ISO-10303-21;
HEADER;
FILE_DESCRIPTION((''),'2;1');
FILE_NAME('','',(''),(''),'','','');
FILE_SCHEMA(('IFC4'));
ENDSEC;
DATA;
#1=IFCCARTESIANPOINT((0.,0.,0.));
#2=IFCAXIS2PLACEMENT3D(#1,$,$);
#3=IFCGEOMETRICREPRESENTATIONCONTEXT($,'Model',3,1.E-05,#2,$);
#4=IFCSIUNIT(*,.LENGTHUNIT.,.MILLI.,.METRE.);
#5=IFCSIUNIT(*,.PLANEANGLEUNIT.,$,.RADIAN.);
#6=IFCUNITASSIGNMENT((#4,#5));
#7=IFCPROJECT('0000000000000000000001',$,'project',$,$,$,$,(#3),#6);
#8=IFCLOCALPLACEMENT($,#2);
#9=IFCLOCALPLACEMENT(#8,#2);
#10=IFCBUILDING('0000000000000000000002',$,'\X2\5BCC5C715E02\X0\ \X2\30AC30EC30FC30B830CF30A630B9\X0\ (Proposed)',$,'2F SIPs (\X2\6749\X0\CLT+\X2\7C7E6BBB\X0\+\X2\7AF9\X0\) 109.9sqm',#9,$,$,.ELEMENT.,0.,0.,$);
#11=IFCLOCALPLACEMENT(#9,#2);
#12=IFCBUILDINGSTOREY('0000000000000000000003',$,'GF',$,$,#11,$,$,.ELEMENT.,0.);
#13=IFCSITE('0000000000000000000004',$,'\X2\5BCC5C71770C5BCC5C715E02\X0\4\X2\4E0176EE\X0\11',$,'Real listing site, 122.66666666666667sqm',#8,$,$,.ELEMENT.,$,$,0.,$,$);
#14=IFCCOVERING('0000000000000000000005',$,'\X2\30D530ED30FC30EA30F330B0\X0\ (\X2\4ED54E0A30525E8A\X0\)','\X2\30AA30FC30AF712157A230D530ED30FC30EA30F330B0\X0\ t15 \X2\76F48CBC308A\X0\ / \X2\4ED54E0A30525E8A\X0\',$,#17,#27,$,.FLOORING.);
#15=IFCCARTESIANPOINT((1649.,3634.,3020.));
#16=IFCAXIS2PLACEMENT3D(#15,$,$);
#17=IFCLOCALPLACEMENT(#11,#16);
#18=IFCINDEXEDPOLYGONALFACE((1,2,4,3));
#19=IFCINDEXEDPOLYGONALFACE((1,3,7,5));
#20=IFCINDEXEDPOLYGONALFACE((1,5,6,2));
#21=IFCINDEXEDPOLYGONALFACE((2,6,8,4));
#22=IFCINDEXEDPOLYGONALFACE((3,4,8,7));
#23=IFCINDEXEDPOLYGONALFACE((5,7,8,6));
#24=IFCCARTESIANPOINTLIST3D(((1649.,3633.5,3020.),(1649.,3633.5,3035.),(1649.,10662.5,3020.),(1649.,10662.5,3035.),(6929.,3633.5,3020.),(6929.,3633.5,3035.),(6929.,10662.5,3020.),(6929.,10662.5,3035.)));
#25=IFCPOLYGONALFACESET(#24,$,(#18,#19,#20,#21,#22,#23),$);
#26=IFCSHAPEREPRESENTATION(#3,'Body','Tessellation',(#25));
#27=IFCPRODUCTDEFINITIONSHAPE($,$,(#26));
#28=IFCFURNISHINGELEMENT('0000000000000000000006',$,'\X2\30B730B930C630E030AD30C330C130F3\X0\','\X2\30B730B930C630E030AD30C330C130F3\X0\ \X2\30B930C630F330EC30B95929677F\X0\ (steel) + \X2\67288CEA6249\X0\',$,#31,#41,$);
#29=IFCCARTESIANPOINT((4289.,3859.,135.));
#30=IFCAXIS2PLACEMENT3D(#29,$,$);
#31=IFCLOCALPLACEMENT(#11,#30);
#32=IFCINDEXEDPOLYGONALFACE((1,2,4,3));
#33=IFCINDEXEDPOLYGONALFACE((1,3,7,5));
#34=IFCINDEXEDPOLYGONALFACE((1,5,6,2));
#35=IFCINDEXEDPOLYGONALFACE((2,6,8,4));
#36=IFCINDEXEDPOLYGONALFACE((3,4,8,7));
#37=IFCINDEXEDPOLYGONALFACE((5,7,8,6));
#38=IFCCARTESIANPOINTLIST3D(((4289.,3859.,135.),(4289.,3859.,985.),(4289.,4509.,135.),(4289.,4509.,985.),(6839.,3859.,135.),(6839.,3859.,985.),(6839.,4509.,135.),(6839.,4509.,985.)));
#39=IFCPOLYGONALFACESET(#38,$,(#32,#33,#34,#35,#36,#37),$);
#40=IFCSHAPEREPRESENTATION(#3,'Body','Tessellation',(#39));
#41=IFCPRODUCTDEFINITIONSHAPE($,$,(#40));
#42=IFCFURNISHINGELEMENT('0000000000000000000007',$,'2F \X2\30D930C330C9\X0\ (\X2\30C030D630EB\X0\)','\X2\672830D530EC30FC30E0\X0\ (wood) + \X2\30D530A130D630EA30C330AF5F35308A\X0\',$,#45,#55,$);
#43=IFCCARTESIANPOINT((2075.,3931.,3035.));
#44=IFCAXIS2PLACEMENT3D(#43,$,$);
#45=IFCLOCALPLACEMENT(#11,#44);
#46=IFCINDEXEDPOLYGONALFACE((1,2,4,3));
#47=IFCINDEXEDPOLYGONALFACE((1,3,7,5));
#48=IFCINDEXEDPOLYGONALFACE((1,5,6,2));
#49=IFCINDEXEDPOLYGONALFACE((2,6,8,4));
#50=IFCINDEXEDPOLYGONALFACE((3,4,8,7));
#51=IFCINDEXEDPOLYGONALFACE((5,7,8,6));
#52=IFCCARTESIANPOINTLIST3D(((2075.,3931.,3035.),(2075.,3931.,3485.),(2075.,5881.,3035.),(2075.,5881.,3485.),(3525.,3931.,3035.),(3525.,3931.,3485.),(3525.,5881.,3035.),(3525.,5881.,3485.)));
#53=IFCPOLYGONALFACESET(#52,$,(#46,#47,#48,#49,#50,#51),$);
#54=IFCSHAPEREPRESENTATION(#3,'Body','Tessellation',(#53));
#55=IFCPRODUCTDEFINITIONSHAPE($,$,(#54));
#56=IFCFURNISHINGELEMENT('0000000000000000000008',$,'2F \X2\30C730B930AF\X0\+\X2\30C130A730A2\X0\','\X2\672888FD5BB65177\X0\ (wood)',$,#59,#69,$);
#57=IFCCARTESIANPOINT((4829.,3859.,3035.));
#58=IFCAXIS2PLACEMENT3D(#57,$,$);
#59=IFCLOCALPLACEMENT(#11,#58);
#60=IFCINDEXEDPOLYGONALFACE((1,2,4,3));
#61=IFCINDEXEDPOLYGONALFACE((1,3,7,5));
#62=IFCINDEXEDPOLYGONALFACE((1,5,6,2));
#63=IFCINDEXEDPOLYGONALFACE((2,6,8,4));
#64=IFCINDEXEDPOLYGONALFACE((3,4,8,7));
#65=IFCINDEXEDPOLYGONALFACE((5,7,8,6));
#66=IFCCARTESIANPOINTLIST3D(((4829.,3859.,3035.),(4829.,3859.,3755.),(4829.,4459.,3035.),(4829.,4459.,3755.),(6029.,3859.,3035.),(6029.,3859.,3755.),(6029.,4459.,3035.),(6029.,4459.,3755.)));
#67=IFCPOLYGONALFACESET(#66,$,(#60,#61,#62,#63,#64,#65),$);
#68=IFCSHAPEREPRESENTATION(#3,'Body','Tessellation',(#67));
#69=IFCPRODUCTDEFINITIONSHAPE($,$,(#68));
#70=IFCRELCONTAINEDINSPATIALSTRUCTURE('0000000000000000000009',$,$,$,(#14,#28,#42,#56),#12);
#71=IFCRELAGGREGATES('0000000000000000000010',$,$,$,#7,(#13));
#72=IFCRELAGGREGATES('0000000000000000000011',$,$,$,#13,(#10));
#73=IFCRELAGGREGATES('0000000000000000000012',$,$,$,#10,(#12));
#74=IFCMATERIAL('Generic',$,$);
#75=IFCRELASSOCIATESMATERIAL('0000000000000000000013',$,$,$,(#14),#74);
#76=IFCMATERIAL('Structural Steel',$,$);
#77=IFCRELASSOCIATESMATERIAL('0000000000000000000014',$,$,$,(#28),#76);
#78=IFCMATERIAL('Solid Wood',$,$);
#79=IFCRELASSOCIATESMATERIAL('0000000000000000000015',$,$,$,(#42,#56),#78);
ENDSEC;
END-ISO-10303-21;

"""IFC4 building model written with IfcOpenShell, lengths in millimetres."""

from ifc_helpers import new_model, si_unit, frame, frame_2d, origin, place, context, project, spatial, rectangle, extrude, material, element, save


model = new_model("IFC4")

# Units and contexts
model_context = context("Model", 3, precision=1e-05, world=origin())
ifc_project = project(units=[si_unit("LENGTHUNIT", "METRE", prefix="MILLI"), si_unit("PLANEANGLEUNIT", "RADIAN")], contexts=[model_context])

# Site, building, storey
site_placement = place(None, origin())
site = spatial("IfcSite", under=ifc_project, at=site_placement, Name="富山県富山市4丁目11", ObjectType="Real listing site, 122.66666666666667sqm", CompositionType="ELEMENT", RefElevation=0.0)
building_placement = place(site_placement, origin())
building = spatial("IfcBuilding", under=site, at=building_placement, Name="富山市 ガレージハウス (Proposed)", ObjectType="2F SIPs (杉CLT+籾殻+竹) 109.9sqm", CompositionType="ELEMENT", ElevationOfRefHeight=0.0, ElevationOfTerrain=0.0)
storey_placement = place(building_placement, origin())
storey = spatial("IfcBuildingStorey", under=building, at=storey_placement, Name="GF", CompositionType="ELEMENT", Elevation=0.0)

# Shared definitions
ifc_material_1 = material(Name="Solid Wood")

# Shared definitions
ifc_material_2 = material(Name="Generic")

# Shared definitions
ifc_material_3 = material(Name="Structural Steel")

# Covering
covering_placement = place(storey_placement, frame((1649.0, 3634.0, 3020.0)))
element("IfcCovering", 1, at=covering_placement, inside=storey, material=ifc_material_2, Name="フローリング (仕上げ床)", Description="オーク無垢フローリング t15 直貼り / 仕上げ床", PredefinedType="FLOORING", context=model_context, shape_type="SweptSolid", body=[
    extrude(rectangle(XDim=5280.0, YDim=7029.0, at=frame_2d((2640.0, 3514.0))), frame((1649.0, 3634.0, 3020.0)), (0.0, 0.0, 1.0), 15.0),
])

# Furnishing elements
furnishing_1_placement = place(storey_placement, frame((4289.0, 3859.0, 135.0)))
element("IfcFurnishingElement", 2, at=furnishing_1_placement, inside=storey, material=ifc_material_3, Name="システムキッチン", Description="システムキッチン ステンレス天板 (steel) + 木質扉", context=model_context, shape_type="SweptSolid", body=[
    extrude(rectangle(XDim=2550.0, YDim=650.0, at=frame_2d((1275.0, 325.0))), frame((4289.0, 3859.0, 135.0)), (0.0, 0.0, 1.0), 850.0),
])
furnishing_2_placement = place(storey_placement, frame((2075.0, 3931.0, 3035.0)))
element("IfcFurnishingElement", 3, at=furnishing_2_placement, inside=storey, material=ifc_material_1, Name="2F ベッド (ダブル)", Description="木フレーム (wood) + ファブリック張り", context=model_context, shape_type="SweptSolid", body=[
    extrude(rectangle(XDim=1450.0, YDim=1950.0, at=frame_2d((725.0, 975.0))), frame((2075.0, 3931.0, 3035.0)), (0.0, 0.0, 1.0), 450.0),
])
furnishing_3_placement = place(storey_placement, frame((4829.0, 3859.0, 3035.0)))
element("IfcFurnishingElement", 4, at=furnishing_3_placement, inside=storey, material=ifc_material_1, Name="2F デスク+チェア", Description="木製家具 (wood)", context=model_context, shape_type="SweptSolid", body=[
    extrude(rectangle(XDim=1200.0, YDim=600.0, at=frame_2d((600.0, 300.0))), frame((4829.0, 3859.0, 3035.0)), (0.0, 0.0, 1.0), 720.0),
])

save(model, "model.ifc")
